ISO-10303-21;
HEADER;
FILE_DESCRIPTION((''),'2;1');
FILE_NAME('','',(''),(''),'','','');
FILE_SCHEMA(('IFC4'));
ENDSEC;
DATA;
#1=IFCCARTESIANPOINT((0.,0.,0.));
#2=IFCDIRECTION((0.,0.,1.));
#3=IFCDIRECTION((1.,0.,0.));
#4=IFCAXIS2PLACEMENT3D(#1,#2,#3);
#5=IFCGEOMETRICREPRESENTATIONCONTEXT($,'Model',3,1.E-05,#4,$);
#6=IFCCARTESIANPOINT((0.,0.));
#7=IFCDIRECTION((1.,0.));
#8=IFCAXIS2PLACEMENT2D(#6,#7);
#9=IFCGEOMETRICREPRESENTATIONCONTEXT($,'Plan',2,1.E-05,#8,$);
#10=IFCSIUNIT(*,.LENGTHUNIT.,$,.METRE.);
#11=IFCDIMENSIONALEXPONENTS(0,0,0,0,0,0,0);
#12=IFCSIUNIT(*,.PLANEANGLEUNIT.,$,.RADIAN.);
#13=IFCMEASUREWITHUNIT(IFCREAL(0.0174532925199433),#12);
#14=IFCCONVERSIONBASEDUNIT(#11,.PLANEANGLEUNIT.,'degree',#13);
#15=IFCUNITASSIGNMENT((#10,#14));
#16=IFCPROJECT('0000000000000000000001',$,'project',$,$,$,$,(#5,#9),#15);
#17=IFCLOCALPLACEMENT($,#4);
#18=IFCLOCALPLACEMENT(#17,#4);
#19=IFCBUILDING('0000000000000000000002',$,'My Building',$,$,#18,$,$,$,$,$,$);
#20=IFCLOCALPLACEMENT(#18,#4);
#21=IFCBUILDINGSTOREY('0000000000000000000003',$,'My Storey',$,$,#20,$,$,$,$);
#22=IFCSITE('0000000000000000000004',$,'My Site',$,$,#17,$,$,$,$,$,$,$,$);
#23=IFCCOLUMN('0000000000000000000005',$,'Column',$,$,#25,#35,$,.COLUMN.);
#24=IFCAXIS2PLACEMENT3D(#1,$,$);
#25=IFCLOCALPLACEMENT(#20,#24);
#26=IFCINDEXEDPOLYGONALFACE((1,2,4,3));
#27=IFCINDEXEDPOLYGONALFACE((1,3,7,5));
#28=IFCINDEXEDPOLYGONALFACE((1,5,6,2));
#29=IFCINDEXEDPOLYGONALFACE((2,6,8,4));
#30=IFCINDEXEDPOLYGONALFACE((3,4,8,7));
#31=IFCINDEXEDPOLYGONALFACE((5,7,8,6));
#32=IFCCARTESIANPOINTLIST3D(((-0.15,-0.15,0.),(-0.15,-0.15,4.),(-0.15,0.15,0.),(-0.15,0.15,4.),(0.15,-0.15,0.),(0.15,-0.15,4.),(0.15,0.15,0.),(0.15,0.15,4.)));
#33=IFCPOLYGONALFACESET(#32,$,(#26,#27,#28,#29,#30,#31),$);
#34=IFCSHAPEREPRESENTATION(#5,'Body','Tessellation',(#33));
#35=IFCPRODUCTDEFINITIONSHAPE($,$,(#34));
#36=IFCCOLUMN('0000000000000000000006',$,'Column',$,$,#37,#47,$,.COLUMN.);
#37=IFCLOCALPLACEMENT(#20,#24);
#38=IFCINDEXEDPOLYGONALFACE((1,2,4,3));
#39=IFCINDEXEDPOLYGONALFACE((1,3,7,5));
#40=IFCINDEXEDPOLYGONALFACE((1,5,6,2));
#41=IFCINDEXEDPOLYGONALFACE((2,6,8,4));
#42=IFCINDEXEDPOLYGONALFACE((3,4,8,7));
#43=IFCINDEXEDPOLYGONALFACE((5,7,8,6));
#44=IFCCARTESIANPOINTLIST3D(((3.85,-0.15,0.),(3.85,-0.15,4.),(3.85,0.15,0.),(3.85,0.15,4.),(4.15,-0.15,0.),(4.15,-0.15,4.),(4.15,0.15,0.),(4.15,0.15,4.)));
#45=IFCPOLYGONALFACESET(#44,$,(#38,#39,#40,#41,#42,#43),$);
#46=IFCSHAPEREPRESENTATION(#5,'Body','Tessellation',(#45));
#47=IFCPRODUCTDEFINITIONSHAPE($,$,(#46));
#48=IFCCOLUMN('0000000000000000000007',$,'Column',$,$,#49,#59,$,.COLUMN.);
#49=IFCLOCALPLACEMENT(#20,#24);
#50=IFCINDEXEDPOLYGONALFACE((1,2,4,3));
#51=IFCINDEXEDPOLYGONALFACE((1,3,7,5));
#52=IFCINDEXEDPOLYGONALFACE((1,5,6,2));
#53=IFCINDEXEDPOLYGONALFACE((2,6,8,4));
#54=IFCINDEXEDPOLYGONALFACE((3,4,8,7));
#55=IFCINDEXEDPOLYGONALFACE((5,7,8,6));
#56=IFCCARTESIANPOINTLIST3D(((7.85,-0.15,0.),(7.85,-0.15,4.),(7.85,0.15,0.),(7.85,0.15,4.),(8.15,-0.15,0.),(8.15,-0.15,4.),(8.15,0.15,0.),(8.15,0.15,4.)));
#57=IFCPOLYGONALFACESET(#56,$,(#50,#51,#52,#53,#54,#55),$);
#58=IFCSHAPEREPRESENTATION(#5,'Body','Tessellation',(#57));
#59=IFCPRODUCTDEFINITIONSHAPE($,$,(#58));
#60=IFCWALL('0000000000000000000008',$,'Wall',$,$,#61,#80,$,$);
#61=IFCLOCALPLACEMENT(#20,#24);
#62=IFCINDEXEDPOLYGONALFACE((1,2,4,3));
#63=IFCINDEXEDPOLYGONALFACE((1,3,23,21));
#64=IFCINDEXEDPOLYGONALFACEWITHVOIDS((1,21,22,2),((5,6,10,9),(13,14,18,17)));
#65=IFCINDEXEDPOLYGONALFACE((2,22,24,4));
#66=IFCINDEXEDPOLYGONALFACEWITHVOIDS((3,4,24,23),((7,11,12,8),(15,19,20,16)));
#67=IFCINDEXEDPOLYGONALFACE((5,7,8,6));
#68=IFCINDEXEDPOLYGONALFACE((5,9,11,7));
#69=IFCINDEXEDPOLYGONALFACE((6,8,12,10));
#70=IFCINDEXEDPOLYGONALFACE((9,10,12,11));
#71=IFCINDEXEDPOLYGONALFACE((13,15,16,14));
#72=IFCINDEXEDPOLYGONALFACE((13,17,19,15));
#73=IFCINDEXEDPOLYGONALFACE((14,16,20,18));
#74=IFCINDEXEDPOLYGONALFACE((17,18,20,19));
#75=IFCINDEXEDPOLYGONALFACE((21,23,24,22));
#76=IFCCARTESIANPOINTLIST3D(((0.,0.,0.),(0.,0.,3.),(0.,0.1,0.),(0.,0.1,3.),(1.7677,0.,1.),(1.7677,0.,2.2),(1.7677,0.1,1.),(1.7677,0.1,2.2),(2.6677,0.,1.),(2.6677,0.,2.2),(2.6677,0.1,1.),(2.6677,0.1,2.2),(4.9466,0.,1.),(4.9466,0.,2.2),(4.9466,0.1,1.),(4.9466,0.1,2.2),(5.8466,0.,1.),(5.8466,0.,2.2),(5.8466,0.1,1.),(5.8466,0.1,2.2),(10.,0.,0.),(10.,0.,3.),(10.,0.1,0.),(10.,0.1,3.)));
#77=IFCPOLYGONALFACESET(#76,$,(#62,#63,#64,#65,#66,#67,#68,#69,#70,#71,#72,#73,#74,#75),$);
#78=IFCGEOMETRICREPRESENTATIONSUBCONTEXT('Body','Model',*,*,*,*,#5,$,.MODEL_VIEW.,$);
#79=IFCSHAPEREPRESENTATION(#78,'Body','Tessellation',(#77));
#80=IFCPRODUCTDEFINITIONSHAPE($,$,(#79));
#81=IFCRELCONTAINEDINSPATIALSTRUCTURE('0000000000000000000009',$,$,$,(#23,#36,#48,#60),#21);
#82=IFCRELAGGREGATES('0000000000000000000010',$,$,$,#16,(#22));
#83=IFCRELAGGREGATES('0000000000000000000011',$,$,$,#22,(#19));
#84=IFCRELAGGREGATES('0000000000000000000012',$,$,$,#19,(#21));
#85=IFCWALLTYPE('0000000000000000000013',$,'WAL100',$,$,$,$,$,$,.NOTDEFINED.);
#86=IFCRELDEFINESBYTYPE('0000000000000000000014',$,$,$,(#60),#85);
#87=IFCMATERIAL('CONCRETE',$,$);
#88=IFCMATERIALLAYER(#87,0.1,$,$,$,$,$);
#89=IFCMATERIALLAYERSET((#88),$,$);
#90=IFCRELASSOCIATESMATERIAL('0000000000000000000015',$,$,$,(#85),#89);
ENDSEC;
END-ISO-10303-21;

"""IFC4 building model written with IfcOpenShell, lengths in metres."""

from ifc_helpers import new_model, entity, si_unit, converted_unit, frame, origin, origin_with_axes, origin_2d, origin_2d_with_axis, place, context, subcontext, project, spatial, line, indexed_curve, rectangle, outline, extrude, source, transform, mapped, material, layer, layer_set, type_object, element, save


model = new_model("IFC4")

# Units and contexts
model_context = context("Model", 3, precision=1e-05, world=origin_with_axes())
plan_context = context("Plan", 2, precision=1e-05, world=origin_2d_with_axis())
body_context = subcontext(model_context, "Body", "Model", "MODEL_VIEW")
ifc_project = project(units=[si_unit("LENGTHUNIT", "METRE"), converted_unit("PLANEANGLEUNIT", "degree", entity("IfcReal", 0.0174532925199433), si_unit("PLANEANGLEUNIT", "RADIAN"), dimensions=[0, 0, 0, 0, 0, 0, 0])], contexts=[model_context, plan_context])

# Site, building, storey
site_placement = place(None, origin_with_axes())
site = spatial("IfcSite", under=ifc_project, at=site_placement, Name="My Site")
building_placement = place(site_placement, origin_with_axes())
building = spatial("IfcBuilding", under=site, at=building_placement, Name="My Building")
storey_placement = place(building_placement, origin_with_axes())
storey = spatial("IfcBuildingStorey", under=building, at=storey_placement, Name="My Storey")

# Columns
for number, where, z_axis, x_axis, name in (
    (1, (0.0, 0.0, 0.0), (0.0, 0.0, 1.0), (1.0, 0.0, 0.0), "Column"),
    (2, (4.0, 0.0, 0.0), (0.0, 0.0, 1.0), (1.0, 0.0, 0.0), "Column"),
    (3, (8.0, 0.0, 0.0), (0.0, 0.0, 1.0), (1.0, 0.0, 0.0), "Column"),
):
    element("IfcColumn", number, at=place(storey_placement, frame(where, z_axis=z_axis, x_axis=x_axis)), inside=storey, Name=name, PredefinedType="COLUMN", context=model_context, shape_type="SweptSolid", body=[
        extrude(rectangle(XDim=0.3, YDim=0.3, at=origin_2d()), origin(), (0.0, 0.0, 1.0), 4.0),
    ])

# Wall, openings
ifc_material = material(Name="CONCRETE")
ifc_layer = layer(ifc_material, 0.1)
ifc_layer_set = layer_set([ifc_layer])
wall_type = type_object("IfcWallType", Name="WAL100", PredefinedType="NOTDEFINED", material=ifc_layer_set)
wall_placement = place(storey_placement, origin_with_axes())
wall = element("IfcWall", 4, at=wall_placement, inside=storey, type_object=wall_type, Name="Wall", context=body_context, shape_type="SweptSolid", body=[
    extrude(outline(indexed_curve([(0.0, 0.0), (0.0, 0.1), (10.0, 0.1), (10.0, 0.0), (0.0, 0.0)], self_intersect=False)), origin_with_axes(), (0.0, 0.0, 1.0), 3.0),
])
shared_shape = source(origin_with_axes(), body_context, "Body", "SweptSolid", [
    extrude(outline(indexed_curve([(0.0, 0.0), (0.9, 0.0), (0.9, 1.2), (0.0, 1.2)], segments=[line(1, 2, 3, 4, 1)])), frame((0.0, -0.6, 0.0), z_axis=(0.0, -1.0, 0.0), x_axis=(1.0, 0.0, 0.0)), (0.0, 0.0, -1.0), 1.2),
])
opening_1_placement = place(wall_placement, frame((1.7677, 0.0, 1.0), z_axis=(0.0, 0.0, 1.0), x_axis=(1.0, 0.0, 0.0)))
element("IfcOpeningElement", 5, at=opening_1_placement, cuts=wall, PredefinedType="OPENING", context=body_context, shape_type="MappedRepresentation", body=[
    mapped(shared_shape, transform((0.0, 0.0, 0.0), x_axis=(1.0, 0.0, 0.0), y_axis=(0.0, 1.0, 0.0), z_axis=(0.0, 0.0, 1.0), scale=1.0)),
])
opening_2_placement = place(wall_placement, frame((4.9466, 0.0, 1.0), z_axis=(0.0, 0.0, 1.0), x_axis=(1.0, 0.0, 0.0)))
element("IfcOpeningElement", 6, at=opening_2_placement, cuts=wall, PredefinedType="OPENING", context=body_context, shape_type="MappedRepresentation", body=[
    mapped(shared_shape, transform((0.0, 0.0, 0.0), x_axis=(1.0, 0.0, 0.0), y_axis=(0.0, 1.0, 0.0), z_axis=(0.0, 0.0, 1.0), scale=1.0)),
])

save(model, "model.ifc")
